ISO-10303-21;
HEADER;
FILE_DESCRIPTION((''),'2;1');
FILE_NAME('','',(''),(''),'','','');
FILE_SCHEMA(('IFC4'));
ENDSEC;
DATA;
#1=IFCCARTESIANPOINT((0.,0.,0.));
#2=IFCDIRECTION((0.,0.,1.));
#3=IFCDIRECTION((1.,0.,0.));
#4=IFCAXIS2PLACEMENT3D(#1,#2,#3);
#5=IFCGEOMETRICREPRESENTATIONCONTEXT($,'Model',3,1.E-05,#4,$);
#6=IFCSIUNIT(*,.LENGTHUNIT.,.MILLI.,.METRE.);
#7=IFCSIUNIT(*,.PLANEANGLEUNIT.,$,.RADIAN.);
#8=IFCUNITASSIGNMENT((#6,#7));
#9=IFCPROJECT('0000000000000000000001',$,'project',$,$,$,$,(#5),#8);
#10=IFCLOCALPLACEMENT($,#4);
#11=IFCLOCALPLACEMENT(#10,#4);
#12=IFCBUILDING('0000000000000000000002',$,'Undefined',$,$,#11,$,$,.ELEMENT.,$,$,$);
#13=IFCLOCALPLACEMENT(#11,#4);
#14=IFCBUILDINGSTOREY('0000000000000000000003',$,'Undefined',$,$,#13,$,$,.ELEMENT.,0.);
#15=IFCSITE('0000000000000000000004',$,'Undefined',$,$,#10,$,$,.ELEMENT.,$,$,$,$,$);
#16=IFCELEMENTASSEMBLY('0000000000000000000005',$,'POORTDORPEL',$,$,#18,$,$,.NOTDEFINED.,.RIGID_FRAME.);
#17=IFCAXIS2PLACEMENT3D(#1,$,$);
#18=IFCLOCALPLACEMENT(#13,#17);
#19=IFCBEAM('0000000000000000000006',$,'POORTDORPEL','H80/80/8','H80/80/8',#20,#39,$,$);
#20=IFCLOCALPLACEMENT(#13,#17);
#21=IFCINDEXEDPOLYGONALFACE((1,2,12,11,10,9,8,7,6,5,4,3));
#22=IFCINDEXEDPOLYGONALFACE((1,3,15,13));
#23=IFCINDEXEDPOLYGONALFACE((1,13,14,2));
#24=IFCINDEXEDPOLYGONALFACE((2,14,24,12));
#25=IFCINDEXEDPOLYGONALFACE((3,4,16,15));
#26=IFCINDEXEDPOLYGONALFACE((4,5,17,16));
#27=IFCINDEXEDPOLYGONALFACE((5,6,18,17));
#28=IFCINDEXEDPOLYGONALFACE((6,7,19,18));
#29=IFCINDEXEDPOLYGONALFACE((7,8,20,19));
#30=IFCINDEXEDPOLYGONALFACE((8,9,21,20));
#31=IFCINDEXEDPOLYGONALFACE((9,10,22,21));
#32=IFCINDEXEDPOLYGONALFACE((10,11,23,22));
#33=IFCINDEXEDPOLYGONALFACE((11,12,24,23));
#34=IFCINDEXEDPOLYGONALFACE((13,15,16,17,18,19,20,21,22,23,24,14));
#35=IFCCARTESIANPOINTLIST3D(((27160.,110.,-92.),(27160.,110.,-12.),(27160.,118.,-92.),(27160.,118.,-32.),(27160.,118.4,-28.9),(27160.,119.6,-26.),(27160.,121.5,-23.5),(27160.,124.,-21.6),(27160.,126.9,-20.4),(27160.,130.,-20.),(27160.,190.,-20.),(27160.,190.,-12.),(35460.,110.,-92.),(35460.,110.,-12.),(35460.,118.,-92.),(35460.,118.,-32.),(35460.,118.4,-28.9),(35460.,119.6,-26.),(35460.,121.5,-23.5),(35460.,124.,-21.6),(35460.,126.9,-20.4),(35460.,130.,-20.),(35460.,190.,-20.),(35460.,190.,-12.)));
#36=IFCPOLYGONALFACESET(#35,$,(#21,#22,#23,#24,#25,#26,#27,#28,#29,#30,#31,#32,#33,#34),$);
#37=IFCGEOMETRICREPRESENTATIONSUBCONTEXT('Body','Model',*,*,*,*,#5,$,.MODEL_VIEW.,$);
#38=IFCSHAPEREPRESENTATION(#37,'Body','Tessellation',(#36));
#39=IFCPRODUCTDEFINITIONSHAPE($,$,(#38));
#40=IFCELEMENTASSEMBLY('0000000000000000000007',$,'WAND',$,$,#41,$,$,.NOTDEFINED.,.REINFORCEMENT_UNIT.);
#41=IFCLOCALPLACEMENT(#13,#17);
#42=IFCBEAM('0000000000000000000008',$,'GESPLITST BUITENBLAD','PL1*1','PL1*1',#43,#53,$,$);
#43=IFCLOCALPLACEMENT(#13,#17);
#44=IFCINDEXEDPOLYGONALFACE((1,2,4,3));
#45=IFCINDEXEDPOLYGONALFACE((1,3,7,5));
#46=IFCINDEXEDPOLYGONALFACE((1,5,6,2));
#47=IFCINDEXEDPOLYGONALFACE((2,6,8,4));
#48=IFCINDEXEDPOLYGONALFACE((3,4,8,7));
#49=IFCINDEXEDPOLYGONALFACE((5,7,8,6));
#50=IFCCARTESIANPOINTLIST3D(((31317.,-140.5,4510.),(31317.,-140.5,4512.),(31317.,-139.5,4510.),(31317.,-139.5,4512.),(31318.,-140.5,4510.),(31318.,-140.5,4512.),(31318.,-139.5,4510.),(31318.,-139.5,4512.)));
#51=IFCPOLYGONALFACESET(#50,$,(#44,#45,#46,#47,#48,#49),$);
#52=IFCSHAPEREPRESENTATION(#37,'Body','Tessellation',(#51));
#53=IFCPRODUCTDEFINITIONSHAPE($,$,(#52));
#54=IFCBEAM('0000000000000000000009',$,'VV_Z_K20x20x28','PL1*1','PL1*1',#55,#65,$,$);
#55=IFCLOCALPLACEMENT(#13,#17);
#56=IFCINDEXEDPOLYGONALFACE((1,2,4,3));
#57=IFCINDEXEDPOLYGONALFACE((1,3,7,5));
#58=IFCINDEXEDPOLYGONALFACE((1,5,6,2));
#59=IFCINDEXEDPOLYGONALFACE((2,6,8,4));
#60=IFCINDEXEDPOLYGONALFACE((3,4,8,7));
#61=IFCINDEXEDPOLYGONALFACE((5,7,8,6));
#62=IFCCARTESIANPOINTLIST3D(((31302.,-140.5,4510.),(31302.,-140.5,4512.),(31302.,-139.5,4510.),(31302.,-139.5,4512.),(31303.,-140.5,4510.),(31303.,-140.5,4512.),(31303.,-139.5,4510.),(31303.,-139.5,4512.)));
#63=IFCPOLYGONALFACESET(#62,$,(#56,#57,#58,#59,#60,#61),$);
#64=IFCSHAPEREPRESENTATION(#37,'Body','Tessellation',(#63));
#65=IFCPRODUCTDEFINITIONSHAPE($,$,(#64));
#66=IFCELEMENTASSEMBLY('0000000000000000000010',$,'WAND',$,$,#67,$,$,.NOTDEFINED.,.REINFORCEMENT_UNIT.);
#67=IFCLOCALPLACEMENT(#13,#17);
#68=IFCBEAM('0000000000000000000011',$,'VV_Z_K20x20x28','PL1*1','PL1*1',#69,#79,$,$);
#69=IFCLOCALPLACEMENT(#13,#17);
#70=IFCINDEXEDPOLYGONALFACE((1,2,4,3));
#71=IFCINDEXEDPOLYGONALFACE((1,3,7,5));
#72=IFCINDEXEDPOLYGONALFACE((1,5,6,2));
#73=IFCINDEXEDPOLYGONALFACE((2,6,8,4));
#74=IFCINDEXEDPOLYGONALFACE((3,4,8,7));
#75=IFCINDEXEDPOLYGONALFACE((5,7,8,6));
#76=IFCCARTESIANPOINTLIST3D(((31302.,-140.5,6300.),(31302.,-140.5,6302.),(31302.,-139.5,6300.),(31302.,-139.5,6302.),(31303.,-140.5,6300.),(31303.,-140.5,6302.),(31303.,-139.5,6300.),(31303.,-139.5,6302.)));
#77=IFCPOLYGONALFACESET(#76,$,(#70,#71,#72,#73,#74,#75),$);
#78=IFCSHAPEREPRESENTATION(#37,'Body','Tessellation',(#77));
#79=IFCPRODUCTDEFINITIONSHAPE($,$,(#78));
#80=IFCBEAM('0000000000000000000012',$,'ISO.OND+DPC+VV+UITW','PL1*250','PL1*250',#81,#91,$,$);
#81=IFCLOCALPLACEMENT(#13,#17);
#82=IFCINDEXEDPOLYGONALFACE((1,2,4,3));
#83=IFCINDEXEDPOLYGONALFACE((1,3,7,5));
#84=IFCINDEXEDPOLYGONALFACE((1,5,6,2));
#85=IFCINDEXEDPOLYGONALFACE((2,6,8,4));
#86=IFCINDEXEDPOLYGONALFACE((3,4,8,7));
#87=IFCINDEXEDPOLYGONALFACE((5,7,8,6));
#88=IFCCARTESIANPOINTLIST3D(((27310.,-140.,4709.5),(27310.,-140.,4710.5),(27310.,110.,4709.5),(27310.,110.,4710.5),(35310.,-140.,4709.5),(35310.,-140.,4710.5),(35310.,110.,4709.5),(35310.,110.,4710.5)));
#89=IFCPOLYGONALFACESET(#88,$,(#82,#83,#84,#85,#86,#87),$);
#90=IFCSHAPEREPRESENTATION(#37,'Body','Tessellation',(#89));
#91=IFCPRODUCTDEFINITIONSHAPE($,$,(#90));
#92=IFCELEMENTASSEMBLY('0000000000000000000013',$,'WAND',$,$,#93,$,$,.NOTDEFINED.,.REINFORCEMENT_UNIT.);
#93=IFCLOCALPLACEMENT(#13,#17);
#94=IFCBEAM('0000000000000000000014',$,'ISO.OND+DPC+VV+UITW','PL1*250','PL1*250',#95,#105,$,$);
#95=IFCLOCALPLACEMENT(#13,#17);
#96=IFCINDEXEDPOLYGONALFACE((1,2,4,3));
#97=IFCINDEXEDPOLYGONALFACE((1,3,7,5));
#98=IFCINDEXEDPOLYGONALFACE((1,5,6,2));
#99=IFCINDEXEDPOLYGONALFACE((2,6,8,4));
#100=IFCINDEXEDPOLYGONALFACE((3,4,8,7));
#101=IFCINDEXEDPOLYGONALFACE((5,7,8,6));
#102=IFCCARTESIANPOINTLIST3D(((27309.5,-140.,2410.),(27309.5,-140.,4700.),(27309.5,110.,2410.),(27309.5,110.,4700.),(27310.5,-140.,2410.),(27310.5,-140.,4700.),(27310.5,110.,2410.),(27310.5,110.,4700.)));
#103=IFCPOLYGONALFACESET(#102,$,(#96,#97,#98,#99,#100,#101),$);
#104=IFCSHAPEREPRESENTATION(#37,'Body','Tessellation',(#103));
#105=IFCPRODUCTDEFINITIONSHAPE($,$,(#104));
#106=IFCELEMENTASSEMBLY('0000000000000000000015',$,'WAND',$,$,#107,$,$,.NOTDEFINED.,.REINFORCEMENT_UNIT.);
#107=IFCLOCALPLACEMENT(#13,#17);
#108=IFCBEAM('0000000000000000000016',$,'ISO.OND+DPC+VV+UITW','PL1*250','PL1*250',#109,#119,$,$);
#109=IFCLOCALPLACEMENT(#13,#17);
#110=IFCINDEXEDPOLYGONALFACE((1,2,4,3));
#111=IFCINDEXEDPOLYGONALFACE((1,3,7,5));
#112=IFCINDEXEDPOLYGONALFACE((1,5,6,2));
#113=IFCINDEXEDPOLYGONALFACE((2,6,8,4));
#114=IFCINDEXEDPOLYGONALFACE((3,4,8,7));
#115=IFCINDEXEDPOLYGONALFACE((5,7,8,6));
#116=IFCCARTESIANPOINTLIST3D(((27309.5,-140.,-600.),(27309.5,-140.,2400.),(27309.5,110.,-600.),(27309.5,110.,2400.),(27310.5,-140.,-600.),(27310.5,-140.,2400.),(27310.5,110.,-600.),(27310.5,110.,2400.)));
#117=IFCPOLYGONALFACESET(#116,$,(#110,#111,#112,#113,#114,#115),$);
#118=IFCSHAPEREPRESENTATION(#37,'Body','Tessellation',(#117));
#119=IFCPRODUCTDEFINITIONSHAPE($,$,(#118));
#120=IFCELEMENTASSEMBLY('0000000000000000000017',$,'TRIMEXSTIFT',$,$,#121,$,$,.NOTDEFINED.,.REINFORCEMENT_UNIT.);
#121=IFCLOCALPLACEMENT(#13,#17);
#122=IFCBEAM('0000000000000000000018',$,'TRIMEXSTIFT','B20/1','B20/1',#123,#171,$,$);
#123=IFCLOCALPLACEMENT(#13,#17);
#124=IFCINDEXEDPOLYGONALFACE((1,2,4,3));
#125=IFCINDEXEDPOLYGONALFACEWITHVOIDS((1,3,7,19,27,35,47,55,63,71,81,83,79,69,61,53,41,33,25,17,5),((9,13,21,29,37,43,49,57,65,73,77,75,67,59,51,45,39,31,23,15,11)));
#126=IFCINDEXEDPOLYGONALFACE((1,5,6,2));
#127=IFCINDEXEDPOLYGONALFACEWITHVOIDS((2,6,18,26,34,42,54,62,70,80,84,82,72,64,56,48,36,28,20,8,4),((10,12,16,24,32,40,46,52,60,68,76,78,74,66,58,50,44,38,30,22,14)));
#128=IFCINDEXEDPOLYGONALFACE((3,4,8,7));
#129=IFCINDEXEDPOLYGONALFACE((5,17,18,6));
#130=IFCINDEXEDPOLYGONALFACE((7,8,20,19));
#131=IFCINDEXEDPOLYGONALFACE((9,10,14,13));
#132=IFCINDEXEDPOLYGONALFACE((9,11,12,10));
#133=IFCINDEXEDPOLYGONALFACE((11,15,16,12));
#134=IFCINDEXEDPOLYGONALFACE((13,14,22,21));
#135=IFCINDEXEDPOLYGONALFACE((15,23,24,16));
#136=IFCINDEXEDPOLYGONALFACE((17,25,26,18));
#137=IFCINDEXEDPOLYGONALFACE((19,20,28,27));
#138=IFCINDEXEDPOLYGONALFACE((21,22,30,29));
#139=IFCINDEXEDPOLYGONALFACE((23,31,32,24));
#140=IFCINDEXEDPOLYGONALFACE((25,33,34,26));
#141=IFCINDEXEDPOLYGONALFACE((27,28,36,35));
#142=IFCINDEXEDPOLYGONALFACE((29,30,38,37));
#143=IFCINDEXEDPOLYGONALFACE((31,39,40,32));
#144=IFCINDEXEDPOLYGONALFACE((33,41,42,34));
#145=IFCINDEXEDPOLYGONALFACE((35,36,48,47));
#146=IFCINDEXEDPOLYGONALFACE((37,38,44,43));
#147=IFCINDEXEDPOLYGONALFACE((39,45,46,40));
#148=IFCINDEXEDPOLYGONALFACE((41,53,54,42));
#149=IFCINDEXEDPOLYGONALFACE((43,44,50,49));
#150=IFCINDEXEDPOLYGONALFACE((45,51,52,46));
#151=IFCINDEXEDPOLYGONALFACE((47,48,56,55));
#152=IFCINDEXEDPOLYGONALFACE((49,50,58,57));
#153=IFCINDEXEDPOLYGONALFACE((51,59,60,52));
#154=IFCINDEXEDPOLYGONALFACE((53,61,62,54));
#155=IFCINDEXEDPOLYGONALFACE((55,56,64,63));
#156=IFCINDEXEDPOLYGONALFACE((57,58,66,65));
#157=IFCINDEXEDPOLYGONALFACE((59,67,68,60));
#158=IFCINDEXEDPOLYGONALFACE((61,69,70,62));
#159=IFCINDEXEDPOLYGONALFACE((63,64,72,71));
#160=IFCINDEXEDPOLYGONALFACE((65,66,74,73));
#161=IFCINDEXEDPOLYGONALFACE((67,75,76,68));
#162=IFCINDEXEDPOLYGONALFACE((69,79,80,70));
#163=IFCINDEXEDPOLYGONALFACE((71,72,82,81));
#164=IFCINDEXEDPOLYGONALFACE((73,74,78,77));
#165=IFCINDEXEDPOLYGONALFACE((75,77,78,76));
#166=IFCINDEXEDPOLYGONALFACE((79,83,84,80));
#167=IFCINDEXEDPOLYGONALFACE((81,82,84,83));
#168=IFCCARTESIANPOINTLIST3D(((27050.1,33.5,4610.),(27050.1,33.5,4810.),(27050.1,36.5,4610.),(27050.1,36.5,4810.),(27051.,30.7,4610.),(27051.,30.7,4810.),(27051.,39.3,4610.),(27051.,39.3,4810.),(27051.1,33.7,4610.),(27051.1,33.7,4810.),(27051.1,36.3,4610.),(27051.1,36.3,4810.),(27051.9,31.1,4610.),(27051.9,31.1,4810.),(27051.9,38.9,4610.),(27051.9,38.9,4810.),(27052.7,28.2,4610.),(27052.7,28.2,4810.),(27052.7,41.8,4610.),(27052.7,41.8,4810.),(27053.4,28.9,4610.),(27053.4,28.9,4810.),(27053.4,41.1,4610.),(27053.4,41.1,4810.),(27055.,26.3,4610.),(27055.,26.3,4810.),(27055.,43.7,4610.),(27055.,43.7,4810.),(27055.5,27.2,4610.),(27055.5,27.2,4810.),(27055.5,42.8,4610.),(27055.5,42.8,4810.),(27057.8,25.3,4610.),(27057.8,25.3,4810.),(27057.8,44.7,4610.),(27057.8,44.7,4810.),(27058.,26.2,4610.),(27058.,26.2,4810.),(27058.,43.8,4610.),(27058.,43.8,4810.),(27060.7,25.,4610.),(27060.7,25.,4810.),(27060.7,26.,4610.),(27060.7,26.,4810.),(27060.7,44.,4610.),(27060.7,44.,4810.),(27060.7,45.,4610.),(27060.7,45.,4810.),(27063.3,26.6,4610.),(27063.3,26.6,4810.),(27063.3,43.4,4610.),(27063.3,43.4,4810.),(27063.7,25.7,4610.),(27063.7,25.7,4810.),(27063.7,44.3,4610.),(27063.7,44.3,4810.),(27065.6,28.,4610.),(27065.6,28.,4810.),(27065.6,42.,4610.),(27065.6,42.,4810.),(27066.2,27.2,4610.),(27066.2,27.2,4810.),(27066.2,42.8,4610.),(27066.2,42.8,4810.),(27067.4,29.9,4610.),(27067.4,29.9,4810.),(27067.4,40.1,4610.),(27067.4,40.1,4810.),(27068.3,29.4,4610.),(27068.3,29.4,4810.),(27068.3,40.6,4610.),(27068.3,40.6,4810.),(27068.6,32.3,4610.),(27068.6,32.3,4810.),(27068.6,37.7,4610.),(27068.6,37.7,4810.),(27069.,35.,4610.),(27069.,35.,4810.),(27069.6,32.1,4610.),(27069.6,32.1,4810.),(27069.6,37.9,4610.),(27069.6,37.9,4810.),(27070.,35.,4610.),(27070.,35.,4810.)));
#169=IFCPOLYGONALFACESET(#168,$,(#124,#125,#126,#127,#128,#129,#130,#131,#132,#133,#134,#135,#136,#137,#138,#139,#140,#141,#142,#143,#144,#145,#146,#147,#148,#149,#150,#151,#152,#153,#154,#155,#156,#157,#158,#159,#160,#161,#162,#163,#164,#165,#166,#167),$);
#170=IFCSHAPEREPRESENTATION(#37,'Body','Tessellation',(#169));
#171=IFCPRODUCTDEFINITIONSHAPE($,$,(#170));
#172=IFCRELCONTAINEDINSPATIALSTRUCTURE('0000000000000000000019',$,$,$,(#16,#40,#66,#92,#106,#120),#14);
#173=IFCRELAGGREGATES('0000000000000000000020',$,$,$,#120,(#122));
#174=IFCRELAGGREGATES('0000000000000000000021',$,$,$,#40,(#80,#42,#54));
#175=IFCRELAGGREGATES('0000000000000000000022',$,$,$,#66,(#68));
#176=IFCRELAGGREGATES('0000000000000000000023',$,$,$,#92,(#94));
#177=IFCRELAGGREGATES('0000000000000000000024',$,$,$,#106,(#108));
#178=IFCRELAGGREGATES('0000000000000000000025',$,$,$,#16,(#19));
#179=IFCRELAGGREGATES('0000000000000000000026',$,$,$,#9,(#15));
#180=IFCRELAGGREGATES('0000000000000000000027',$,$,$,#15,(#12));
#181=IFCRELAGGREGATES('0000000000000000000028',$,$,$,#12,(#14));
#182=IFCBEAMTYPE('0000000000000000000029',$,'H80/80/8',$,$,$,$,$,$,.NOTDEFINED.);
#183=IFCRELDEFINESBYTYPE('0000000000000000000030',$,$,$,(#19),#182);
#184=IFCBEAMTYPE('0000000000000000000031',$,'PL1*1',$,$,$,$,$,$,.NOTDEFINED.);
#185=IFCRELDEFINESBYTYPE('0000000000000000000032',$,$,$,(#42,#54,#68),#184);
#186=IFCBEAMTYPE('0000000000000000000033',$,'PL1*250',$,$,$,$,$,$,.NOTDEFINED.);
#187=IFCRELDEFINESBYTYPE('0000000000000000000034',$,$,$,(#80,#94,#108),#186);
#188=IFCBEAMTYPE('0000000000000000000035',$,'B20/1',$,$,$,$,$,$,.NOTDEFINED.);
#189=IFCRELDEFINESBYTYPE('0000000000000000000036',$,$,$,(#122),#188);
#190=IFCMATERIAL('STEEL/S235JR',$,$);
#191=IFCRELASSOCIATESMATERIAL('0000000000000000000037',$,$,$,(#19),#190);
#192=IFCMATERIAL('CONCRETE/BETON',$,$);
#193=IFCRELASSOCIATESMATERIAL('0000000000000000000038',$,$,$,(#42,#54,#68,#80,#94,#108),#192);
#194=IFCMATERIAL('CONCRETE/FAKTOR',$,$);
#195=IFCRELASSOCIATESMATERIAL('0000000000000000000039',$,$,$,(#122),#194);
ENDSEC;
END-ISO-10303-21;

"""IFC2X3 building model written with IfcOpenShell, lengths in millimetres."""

from ifc_helpers import new_model, si_unit, frame, frame_2d, origin_with_axes, place, context, subcontext, project, spatial, rectangle, hollow_circle, l_section, extrude, material, type_object, element, aggregate, save


model = new_model("IFC2X3")

# Units and contexts
model_context = context("Model", 3, precision=1e-05, world=origin_with_axes())
body_context = subcontext(model_context, "Body", "Model", "MODEL_VIEW")
ifc_project = project(units=[si_unit("LENGTHUNIT", "METRE", prefix="MILLI"), si_unit("PLANEANGLEUNIT", "RADIAN")], contexts=[model_context])

# Site, building, storey
site_placement = place(None, origin_with_axes())
site = spatial("IfcSite", under=ifc_project, at=site_placement, Name="Undefined", CompositionType="ELEMENT")
building_placement = place(site_placement, origin_with_axes())
building = spatial("IfcBuilding", under=site, at=building_placement, Name="Undefined", CompositionType="ELEMENT")
storey_placement = place(building_placement, origin_with_axes())
storey = spatial("IfcBuildingStorey", under=building, at=storey_placement, Name="Undefined", CompositionType="ELEMENT", Elevation=0.0)

# Element assembly, beam
assembly_1_placement = place(storey_placement, origin_with_axes())
assembly_1 = element("IfcElementAssembly", 1, at=assembly_1_placement, inside=storey, Name="POORTDORPEL", AssemblyPlace="NOTDEFINED", PredefinedType="RIGID_FRAME")
ifc_material_1 = material(Name="STEEL/S235JR")
beam_type_1 = type_object("IfcBeamType", Name="H80/80/8", PredefinedType="NOTDEFINED")
beam_1_placement = place(assembly_1_placement, frame((27160.0, 150.0, -52.0), z_axis=(0.0, 0.0, -1.0), x_axis=(1.0, 0.0, 0.0)))
beam_1 = element("IfcBeam", 2, at=beam_1_placement, type_object=beam_type_1, material=ifc_material_1, Name="POORTDORPEL", Description="H80/80/8", ObjectType="H80/80/8", context=body_context, shape_type="SweptSolid", body=[
    extrude(l_section(Depth=80.0, Width=80.0, Thickness=8.0, FilletRadius=12.0, at=frame_2d((0.0, 0.0), x_axis=(1.0, 0.0))), frame((8300.0, 0.0, 0.0), z_axis=(-1.0, 0.0, 0.0), x_axis=(0.0, -1.0, 0.0)), (0.0, 0.0, 1.0), 8300.0),
])

# Element assembly, beams
assembly_2_placement = place(storey_placement, origin_with_axes())
assembly_2 = element("IfcElementAssembly", 3, at=assembly_2_placement, inside=storey, Name="WAND", AssemblyPlace="NOTDEFINED", PredefinedType="REINFORCEMENT_UNIT")
ifc_material_2 = material(Name="CONCRETE/BETON")
beam_type_2 = type_object("IfcBeamType", Name="PL1*1", PredefinedType="NOTDEFINED")
beam_2_placement = place(assembly_2_placement, frame((31317.5, -140.0, 4510.0), z_axis=(1.0, 0.0, 0.0), x_axis=(0.0, 0.0, 1.0)))
beam_2 = element("IfcBeam", 4, at=beam_2_placement, type_object=beam_type_2, material=ifc_material_2, Name="GESPLITST BUITENBLAD", Description="PL1*1", ObjectType="PL1*1", context=body_context, shape_type="SweptSolid", body=[
    extrude(rectangle(XDim=1.0, YDim=1.0, at=frame_2d((0.0, 0.0), x_axis=(1.0, 0.0))), frame((2.0, 0.0, 0.0), z_axis=(-1.0, 0.0, 0.0), x_axis=(0.0, -1.0, 0.0)), (0.0, 0.0, 1.0), 2.0),
])
beam_3_placement = place(assembly_2_placement, frame((31302.5, -140.0, 4510.0), z_axis=(1.0, 0.0, 0.0), x_axis=(0.0, 0.0, 1.0)))
beam_3 = element("IfcBeam", 5, at=beam_3_placement, type_object=beam_type_2, material=ifc_material_2, Name="VV_Z_K20x20x28", Description="PL1*1", ObjectType="PL1*1", context=body_context, shape_type="SweptSolid", body=[
    extrude(rectangle(XDim=1.0, YDim=1.0, at=frame_2d((0.0, 0.0), x_axis=(1.0, 0.0))), frame((2.0, 0.0, 0.0), z_axis=(-1.0, 0.0, 0.0), x_axis=(0.0, -1.0, 0.0)), (0.0, 0.0, 1.0), 2.0),
])

# Element assembly, beam
assembly_3_placement = place(storey_placement, origin_with_axes())
assembly_3 = element("IfcElementAssembly", 6, at=assembly_3_placement, inside=storey, Name="WAND", AssemblyPlace="NOTDEFINED", PredefinedType="REINFORCEMENT_UNIT")
beam_4_placement = place(assembly_3_placement, frame((31302.5, -140.0, 6300.0), z_axis=(1.0, 0.0, 0.0), x_axis=(0.0, 0.0, 1.0)))
beam_4 = element("IfcBeam", 7, at=beam_4_placement, type_object=beam_type_2, material=ifc_material_2, Name="VV_Z_K20x20x28", Description="PL1*1", ObjectType="PL1*1", context=body_context, shape_type="SweptSolid", body=[
    extrude(rectangle(XDim=1.0, YDim=1.0, at=frame_2d((0.0, 0.0), x_axis=(1.0, 0.0))), frame((2.0, 0.0, 0.0), z_axis=(-1.0, 0.0, 0.0), x_axis=(0.0, -1.0, 0.0)), (0.0, 0.0, 1.0), 2.0),
])

# Beam
beam_type_3 = type_object("IfcBeamType", Name="PL1*250", PredefinedType="NOTDEFINED")
beam_5_placement = place(assembly_2_placement, frame((27310.0, -15.0, 4710.0), z_axis=(0.0, -1.0, 0.0), x_axis=(1.0, 0.0, 0.0)))
beam_5 = element("IfcBeam", 8, at=beam_5_placement, type_object=beam_type_3, material=ifc_material_2, Name="ISO.OND+DPC+VV+UITW", Description="PL1*250", ObjectType="PL1*250", context=body_context, shape_type="SweptSolid", body=[
    extrude(rectangle(XDim=1.0, YDim=250.0, at=frame_2d((0.0, 0.0), x_axis=(1.0, 0.0))), frame((8000.0, 0.0, 0.0), z_axis=(-1.0, 0.0, 0.0), x_axis=(0.0, -1.0, 0.0)), (0.0, 0.0, 1.0), 8000.0),
])

# Element assemblies, beams
assembly_4_placement = place(storey_placement, origin_with_axes())
assembly_4 = element("IfcElementAssembly", 9, at=assembly_4_placement, inside=storey, Name="WAND", AssemblyPlace="NOTDEFINED", PredefinedType="REINFORCEMENT_UNIT")
beam_6_placement = place(assembly_4_placement, frame((27310.0, -15.0, 2410.0), z_axis=(0.0, -1.0, 0.0), x_axis=(0.0, 0.0, 1.0)))
beam_6 = element("IfcBeam", 10, at=beam_6_placement, type_object=beam_type_3, material=ifc_material_2, Name="ISO.OND+DPC+VV+UITW", Description="PL1*250", ObjectType="PL1*250", context=body_context, shape_type="SweptSolid", body=[
    extrude(rectangle(XDim=1.0, YDim=250.0, at=frame_2d((0.0, 0.0), x_axis=(1.0, 0.0))), frame((2290.0, 0.0, 0.0), z_axis=(-1.0, 0.0, 0.0), x_axis=(0.0, -1.0, 0.0)), (0.0, 0.0, 1.0), 2290.0),
])
assembly_5_placement = place(storey_placement, origin_with_axes())
assembly_5 = element("IfcElementAssembly", 11, at=assembly_5_placement, inside=storey, Name="WAND", AssemblyPlace="NOTDEFINED", PredefinedType="REINFORCEMENT_UNIT")
beam_7_placement = place(assembly_5_placement, frame((27310.0, -15.0, -600.0), z_axis=(0.0, -1.0, 0.0), x_axis=(0.0, 0.0, 1.0)))
beam_7 = element("IfcBeam", 12, at=beam_7_placement, type_object=beam_type_3, material=ifc_material_2, Name="ISO.OND+DPC+VV+UITW", Description="PL1*250", ObjectType="PL1*250", context=body_context, shape_type="SweptSolid", body=[
    extrude(rectangle(XDim=1.0, YDim=250.0, at=frame_2d((0.0, 0.0), x_axis=(1.0, 0.0))), frame((3000.0, 0.0, 0.0), z_axis=(-1.0, 0.0, 0.0), x_axis=(0.0, -1.0, 0.0)), (0.0, 0.0, 1.0), 3000.0),
])
assembly_6_placement = place(storey_placement, origin_with_axes())
assembly_6 = element("IfcElementAssembly", 13, at=assembly_6_placement, inside=storey, Name="TRIMEXSTIFT", AssemblyPlace="NOTDEFINED", PredefinedType="REINFORCEMENT_UNIT")
ifc_material_3 = material(Name="CONCRETE/FAKTOR")
beam_type_4 = type_object("IfcBeamType", Name="B20/1", PredefinedType="NOTDEFINED")
beam_8_placement = place(assembly_6_placement, frame((27060.0, 35.0, 4610.0), z_axis=(0.0, -1.0, 0.0), x_axis=(0.0, 0.0, 1.0)))
beam_8 = element("IfcBeam", 14, at=beam_8_placement, type_object=beam_type_4, material=ifc_material_3, Name="TRIMEXSTIFT", Description="B20/1", ObjectType="B20/1", context=body_context, shape_type="SweptSolid", body=[
    extrude(hollow_circle(Radius=10.0, WallThickness=1.0, at=frame_2d((0.0, 0.0), x_axis=(1.0, 0.0))), frame((200.0, 0.0, 0.0), z_axis=(-1.0, 0.0, 0.0), x_axis=(0.0, -1.0, 0.0)), (0.0, 0.0, 1.0), 200.0),
])
aggregate(assembly_6, [beam_8])

aggregate(assembly_2, [beam_5, beam_2, beam_3])

aggregate(assembly_3, [beam_4])

aggregate(assembly_4, [beam_6])
aggregate(assembly_5, [beam_7])

aggregate(assembly_1, [beam_1])

save(model, "model.ifc")
